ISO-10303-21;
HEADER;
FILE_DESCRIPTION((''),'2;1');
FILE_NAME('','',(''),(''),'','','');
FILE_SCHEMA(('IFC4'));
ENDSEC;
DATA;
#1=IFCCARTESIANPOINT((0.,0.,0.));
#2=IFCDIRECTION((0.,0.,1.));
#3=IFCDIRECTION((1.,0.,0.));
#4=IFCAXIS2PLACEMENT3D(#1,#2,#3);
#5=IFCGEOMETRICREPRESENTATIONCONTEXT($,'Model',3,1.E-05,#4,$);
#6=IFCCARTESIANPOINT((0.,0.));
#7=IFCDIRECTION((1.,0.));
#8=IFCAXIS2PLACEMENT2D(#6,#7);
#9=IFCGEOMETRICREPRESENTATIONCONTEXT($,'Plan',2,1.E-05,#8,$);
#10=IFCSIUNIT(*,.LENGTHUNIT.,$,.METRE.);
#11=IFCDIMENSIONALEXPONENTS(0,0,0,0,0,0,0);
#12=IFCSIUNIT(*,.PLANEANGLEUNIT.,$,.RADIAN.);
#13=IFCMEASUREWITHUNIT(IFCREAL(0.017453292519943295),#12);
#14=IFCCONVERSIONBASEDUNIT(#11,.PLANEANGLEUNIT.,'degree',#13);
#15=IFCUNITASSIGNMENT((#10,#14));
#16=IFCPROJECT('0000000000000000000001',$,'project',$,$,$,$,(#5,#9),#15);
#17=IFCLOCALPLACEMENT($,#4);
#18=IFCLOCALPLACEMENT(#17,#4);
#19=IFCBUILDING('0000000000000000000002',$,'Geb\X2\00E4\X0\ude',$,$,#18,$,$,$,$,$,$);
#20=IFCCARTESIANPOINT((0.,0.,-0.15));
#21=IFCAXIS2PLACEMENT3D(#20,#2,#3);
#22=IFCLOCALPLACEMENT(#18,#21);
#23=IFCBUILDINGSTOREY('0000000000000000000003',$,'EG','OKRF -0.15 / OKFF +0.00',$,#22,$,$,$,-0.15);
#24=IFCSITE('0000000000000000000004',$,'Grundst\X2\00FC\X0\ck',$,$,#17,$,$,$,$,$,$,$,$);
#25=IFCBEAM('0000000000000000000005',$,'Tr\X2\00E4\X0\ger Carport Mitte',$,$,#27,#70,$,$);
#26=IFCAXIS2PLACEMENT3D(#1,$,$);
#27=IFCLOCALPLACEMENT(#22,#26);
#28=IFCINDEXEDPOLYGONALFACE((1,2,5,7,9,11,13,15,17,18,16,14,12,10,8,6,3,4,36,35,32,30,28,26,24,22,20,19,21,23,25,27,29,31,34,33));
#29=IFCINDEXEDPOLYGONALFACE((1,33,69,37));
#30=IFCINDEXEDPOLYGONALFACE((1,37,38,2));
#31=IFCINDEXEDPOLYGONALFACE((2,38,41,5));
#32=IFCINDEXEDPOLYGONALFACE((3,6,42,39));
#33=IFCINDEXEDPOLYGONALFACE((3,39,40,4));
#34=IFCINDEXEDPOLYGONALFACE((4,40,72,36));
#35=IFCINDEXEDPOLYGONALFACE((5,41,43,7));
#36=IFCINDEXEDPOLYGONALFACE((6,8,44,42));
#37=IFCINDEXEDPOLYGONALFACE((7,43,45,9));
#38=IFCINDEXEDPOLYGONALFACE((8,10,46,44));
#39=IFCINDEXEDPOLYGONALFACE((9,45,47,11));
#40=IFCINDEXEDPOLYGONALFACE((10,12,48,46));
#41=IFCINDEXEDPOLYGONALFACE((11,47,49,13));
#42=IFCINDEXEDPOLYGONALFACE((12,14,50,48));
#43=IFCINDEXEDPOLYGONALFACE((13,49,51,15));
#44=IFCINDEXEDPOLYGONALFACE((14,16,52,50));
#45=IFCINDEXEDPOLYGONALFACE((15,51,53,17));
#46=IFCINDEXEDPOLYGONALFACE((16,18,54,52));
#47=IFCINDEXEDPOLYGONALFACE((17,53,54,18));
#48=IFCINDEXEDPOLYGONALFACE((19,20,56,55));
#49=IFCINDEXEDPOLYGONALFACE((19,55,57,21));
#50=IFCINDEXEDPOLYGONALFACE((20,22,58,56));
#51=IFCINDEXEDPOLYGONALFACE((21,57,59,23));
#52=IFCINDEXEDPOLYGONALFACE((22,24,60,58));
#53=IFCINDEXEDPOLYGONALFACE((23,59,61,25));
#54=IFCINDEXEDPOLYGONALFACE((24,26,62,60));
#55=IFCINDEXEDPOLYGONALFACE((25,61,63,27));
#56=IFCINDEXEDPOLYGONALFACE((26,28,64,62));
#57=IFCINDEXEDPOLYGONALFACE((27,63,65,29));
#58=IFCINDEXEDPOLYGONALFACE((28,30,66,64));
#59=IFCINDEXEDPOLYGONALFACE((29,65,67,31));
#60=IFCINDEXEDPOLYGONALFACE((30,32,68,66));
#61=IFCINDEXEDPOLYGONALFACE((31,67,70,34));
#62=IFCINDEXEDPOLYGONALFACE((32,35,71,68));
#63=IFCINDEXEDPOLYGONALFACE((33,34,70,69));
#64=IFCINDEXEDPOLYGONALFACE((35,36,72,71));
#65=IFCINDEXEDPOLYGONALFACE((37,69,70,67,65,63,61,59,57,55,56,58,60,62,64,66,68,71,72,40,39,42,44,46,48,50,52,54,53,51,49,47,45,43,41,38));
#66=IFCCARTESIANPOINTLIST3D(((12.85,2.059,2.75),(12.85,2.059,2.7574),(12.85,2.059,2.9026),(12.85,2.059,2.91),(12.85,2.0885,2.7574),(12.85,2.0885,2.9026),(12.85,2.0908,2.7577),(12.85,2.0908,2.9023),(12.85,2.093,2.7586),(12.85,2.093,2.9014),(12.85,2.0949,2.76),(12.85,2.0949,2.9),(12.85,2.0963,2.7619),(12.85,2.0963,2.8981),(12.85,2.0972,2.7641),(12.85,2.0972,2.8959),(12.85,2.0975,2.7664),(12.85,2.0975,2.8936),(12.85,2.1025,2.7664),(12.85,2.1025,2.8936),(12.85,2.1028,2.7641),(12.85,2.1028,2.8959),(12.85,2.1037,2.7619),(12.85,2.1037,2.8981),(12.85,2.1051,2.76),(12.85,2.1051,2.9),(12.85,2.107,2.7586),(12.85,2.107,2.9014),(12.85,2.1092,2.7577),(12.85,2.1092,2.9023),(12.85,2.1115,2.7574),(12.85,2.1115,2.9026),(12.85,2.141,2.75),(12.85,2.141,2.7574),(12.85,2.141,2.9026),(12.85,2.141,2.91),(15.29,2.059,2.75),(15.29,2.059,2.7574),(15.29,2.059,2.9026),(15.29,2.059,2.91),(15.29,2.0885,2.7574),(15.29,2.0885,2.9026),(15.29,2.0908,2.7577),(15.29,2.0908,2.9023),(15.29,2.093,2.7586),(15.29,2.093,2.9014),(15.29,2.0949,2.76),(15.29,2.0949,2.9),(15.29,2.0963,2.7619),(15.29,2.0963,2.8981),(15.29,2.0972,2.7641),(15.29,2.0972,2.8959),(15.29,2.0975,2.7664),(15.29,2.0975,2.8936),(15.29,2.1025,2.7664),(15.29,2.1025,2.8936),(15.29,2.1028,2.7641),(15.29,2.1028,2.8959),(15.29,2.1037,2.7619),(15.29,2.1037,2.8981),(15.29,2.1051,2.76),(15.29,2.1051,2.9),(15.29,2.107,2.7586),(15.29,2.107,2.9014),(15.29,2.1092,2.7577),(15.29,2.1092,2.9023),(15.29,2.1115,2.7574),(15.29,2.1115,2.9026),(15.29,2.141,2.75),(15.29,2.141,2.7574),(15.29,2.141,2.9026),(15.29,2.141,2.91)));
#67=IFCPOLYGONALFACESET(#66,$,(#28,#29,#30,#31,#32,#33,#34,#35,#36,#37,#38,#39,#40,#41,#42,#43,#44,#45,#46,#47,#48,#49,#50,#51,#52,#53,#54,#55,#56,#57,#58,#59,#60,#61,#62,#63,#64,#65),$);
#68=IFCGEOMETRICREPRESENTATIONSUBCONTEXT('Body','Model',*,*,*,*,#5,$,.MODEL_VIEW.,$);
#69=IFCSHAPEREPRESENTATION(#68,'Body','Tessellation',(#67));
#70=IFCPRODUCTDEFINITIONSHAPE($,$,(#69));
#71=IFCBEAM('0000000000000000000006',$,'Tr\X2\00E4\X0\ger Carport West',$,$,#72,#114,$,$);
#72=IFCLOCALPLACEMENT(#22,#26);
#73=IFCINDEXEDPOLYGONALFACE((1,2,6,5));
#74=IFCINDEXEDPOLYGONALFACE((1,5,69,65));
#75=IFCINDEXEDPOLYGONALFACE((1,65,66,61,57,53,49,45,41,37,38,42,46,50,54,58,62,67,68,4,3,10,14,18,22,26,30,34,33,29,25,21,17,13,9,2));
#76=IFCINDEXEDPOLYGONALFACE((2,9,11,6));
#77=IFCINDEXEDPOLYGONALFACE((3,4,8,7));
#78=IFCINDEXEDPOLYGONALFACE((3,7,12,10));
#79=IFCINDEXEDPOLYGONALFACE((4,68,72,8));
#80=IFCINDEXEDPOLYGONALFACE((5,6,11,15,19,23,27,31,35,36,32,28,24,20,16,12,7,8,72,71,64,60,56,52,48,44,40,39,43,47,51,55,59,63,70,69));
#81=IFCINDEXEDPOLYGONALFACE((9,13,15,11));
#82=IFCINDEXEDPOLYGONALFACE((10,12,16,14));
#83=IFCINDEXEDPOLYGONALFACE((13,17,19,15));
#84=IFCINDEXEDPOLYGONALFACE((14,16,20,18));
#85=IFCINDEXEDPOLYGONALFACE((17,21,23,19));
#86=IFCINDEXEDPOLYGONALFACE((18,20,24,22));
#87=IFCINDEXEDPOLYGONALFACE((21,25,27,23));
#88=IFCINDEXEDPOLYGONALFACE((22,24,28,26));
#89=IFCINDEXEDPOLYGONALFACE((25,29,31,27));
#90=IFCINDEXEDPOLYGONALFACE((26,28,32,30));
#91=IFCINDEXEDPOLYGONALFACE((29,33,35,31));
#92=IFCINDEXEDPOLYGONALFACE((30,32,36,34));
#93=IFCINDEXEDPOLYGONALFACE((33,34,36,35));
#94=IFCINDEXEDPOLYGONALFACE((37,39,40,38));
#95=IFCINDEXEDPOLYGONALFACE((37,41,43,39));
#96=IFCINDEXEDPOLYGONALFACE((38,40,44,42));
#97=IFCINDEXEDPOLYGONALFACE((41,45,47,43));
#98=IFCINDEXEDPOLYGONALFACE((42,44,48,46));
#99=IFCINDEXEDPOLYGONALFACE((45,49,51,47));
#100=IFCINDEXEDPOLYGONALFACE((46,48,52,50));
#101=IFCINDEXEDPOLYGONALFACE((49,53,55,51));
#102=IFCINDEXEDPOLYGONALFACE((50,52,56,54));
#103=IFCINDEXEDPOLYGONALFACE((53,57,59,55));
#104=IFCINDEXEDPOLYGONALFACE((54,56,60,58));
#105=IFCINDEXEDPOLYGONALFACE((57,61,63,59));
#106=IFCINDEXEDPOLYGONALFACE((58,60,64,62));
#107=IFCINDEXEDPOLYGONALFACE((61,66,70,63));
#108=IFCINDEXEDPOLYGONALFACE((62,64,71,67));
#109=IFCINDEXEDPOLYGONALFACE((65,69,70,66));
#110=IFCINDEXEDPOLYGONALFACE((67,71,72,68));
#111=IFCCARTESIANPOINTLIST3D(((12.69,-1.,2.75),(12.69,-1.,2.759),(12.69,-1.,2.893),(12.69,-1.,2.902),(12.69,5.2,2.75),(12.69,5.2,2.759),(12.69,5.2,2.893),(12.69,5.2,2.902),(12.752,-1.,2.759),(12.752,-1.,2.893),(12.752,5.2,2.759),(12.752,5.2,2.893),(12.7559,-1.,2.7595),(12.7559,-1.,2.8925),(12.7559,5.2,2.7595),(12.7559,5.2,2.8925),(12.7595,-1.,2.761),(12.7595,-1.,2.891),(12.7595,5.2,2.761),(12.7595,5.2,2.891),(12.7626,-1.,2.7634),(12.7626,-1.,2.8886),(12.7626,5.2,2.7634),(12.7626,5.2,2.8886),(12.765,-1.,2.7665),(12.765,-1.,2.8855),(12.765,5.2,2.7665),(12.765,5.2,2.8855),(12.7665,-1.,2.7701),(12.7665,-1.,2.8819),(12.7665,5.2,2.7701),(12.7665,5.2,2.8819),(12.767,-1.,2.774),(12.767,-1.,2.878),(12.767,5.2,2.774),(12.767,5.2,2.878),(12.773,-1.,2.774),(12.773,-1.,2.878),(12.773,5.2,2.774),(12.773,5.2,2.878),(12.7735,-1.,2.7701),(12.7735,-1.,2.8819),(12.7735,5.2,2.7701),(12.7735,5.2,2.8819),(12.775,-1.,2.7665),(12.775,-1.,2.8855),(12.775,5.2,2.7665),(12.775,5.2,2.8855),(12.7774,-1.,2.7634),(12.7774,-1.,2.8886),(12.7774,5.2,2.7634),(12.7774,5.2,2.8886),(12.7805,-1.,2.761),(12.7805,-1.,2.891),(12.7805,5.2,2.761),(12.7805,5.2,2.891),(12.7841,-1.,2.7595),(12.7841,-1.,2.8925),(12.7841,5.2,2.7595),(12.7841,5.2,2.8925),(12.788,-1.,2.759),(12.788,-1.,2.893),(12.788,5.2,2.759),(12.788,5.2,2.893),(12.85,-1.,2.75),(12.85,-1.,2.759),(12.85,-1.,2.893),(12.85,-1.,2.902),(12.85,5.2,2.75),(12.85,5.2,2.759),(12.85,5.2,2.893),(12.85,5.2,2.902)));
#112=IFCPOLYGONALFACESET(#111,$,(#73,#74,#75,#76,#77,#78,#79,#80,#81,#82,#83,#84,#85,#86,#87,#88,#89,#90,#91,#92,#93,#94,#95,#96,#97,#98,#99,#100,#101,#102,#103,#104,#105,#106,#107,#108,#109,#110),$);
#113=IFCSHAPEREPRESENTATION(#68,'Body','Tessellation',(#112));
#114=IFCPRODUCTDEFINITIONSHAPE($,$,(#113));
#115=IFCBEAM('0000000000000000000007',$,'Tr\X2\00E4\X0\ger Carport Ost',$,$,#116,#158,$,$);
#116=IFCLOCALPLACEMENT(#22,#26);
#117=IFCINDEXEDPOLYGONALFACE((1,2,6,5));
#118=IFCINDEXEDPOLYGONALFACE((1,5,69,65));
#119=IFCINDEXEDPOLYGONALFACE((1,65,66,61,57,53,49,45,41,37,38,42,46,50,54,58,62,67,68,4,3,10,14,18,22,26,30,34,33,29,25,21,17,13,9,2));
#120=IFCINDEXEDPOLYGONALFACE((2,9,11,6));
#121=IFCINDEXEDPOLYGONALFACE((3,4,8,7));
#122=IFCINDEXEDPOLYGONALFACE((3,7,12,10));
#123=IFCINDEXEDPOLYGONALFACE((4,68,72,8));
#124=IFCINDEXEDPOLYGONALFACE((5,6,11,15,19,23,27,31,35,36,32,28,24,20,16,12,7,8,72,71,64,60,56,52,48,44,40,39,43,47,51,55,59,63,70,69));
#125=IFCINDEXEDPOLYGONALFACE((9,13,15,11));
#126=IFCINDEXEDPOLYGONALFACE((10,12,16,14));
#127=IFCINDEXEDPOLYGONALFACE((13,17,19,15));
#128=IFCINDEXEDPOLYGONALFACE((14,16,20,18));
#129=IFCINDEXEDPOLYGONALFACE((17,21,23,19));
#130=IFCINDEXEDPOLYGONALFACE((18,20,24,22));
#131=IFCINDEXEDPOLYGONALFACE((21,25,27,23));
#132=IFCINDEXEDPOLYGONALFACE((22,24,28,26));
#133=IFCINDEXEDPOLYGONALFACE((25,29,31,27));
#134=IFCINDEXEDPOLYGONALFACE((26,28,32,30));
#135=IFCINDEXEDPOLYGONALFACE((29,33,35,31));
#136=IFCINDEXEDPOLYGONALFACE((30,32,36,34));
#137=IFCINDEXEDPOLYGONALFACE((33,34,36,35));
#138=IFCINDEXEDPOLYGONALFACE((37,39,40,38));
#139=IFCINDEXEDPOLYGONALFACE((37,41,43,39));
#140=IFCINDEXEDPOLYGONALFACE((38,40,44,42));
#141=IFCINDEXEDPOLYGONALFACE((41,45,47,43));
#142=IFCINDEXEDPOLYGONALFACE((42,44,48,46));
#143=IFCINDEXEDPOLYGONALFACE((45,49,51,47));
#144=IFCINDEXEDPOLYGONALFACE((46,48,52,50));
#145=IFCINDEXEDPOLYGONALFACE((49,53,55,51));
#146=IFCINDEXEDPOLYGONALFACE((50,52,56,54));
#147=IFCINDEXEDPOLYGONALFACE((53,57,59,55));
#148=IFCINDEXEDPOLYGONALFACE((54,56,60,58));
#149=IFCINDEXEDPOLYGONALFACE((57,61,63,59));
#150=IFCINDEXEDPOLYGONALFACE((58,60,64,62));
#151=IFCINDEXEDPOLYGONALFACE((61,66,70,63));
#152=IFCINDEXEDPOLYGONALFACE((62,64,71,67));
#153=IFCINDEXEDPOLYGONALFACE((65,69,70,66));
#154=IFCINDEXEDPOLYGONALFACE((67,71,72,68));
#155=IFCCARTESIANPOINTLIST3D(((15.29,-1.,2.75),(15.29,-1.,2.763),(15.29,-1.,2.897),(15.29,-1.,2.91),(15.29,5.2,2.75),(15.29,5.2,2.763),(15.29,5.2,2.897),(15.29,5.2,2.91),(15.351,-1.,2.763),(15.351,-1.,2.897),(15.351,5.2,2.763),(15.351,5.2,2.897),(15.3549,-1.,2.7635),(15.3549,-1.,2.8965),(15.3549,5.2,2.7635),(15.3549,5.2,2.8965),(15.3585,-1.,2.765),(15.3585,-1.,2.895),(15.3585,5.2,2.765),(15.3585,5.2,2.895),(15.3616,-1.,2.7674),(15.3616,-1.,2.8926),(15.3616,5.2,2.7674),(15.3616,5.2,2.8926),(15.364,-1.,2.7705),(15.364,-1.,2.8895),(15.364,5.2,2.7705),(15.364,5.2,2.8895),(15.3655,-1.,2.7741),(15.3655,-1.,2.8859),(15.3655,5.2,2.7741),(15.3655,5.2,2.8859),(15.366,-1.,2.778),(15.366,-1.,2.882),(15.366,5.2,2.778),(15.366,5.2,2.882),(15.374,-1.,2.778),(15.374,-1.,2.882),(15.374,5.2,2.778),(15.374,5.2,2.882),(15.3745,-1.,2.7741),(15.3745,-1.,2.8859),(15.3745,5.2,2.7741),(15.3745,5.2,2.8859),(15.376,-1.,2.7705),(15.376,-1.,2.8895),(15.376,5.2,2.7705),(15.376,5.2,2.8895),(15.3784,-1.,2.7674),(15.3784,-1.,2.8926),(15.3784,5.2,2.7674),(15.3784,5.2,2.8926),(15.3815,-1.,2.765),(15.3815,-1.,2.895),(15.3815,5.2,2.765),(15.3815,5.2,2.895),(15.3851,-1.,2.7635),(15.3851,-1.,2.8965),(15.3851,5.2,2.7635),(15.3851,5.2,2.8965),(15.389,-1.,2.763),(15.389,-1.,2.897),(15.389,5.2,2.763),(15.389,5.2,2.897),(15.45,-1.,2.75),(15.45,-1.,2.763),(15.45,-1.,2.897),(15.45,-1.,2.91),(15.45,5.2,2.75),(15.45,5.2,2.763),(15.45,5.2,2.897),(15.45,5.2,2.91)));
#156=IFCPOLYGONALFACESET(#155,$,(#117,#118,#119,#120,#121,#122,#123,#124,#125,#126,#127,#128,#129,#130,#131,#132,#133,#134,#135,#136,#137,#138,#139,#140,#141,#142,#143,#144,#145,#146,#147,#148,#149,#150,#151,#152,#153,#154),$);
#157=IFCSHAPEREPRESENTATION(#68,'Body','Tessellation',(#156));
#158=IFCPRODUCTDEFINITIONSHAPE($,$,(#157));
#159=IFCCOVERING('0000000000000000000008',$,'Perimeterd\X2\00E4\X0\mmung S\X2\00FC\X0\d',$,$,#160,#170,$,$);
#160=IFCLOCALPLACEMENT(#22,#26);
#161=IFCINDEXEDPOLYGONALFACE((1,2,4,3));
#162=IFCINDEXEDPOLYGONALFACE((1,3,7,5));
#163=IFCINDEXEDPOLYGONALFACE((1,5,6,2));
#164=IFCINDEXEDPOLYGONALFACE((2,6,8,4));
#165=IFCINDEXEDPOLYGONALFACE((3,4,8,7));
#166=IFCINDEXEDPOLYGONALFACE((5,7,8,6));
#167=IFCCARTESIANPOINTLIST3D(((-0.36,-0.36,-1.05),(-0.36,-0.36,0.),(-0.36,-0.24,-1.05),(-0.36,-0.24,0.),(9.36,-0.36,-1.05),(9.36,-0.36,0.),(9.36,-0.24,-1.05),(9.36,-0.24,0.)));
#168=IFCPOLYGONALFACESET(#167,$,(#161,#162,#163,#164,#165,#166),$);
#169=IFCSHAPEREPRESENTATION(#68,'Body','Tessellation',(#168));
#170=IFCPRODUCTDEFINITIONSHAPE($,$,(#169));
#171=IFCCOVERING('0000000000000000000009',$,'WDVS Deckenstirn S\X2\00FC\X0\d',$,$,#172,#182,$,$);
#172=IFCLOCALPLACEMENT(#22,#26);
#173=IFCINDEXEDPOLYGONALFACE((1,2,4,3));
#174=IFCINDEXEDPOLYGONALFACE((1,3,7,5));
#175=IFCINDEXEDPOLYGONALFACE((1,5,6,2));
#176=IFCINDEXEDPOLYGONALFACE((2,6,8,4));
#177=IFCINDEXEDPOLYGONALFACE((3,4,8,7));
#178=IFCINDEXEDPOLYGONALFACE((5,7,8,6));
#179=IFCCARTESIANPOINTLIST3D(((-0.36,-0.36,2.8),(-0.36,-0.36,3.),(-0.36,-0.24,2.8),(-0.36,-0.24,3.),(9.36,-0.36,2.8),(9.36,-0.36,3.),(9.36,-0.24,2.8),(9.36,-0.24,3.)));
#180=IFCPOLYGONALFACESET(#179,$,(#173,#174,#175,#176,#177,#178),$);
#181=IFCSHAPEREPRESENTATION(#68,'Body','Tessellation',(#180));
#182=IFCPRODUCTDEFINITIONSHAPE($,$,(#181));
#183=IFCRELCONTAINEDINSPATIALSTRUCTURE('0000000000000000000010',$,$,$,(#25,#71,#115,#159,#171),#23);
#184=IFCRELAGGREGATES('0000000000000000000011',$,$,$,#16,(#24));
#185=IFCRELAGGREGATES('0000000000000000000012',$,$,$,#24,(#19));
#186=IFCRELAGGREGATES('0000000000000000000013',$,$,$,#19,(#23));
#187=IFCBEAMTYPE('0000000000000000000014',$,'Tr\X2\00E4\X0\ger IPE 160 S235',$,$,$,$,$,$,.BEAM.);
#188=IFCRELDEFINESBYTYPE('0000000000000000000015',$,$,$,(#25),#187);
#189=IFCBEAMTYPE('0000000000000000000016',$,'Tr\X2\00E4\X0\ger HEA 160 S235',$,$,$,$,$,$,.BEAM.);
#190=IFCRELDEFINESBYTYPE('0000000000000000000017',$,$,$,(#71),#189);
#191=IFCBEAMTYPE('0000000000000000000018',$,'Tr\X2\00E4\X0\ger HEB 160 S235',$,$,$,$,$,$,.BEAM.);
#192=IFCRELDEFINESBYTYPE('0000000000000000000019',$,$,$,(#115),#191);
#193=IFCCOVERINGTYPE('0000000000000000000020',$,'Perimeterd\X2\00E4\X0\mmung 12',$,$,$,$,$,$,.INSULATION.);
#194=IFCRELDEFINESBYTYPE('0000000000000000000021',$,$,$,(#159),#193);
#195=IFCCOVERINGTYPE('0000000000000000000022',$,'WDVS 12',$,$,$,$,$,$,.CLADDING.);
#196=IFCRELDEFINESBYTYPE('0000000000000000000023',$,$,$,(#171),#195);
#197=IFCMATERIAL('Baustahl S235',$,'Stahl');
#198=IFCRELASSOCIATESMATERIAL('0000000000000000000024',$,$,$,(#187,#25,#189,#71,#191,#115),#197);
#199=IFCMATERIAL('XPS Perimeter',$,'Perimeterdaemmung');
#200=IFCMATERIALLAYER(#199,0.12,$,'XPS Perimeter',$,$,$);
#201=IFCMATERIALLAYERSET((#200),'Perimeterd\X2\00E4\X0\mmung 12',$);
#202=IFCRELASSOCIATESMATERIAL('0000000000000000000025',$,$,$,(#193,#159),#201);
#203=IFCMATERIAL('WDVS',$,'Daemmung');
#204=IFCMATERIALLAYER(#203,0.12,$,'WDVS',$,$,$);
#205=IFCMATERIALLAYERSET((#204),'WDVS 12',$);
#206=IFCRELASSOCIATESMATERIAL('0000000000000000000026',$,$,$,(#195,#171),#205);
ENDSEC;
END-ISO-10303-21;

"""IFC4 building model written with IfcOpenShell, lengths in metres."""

from ifc_helpers import new_model, entity, si_unit, converted_unit, frame, origin_with_axes, origin_2d_with_axis, place, context, subcontext, project, spatial, indexed_curve, i_section, outline, extrude, material, layer, layer_set, layer_usage, material_profile, profile_set, profile_usage, type_object, element, save


model = new_model("IFC4")

# Units and contexts
model_context = context("Model", 3, precision=1e-05, world=origin_with_axes())
plan_context = context("Plan", 2, precision=1e-05, world=origin_2d_with_axis())
body_context = subcontext(model_context, "Body", "Model", "MODEL_VIEW")
ifc_project = project(units=[si_unit("LENGTHUNIT", "METRE"), converted_unit("PLANEANGLEUNIT", "degree", entity("IfcReal", 0.017453292519943295), si_unit("PLANEANGLEUNIT", "RADIAN"), dimensions=[0, 0, 0, 0, 0, 0, 0])], contexts=[model_context, plan_context])

# Site, building, storey
site_placement = place(None, origin_with_axes())
site = spatial("IfcSite", under=ifc_project, at=site_placement, Name="Grundstück")
building_placement = place(site_placement, origin_with_axes())
building = spatial("IfcBuilding", under=site, at=building_placement, Name="Gebäude")
storey_placement = place(building_placement, frame((0.0, 0.0, -0.15), z_axis=(0.0, 0.0, 1.0), x_axis=(1.0, 0.0, 0.0)))
storey = spatial("IfcBuildingStorey", under=building, at=storey_placement, Name="EG", Description="OKRF -0.15 / OKFF +0.00", Elevation=-0.15)

# Shared definitions
ifc_material_1 = material(Name="Baustahl S235", Category="Stahl")

# Beams
ifc_material_profile_1 = material_profile(ifc_material_1, i_section(OverallWidth=0.082, OverallDepth=0.16, WebThickness=0.005, FlangeThickness=0.0074, FilletRadius=0.009))
ifc_profile_set_1 = profile_set([ifc_material_profile_1], Name="Träger IPE 160 S235")
ifc_profile_usage_1 = profile_usage(ifc_profile_set_1)
beam_type_1 = type_object("IfcBeamType", Name="Träger IPE 160 S235", PredefinedType="BEAM", material=ifc_profile_set_1)
beam_1_placement = place(storey_placement, frame((12.85, 2.1, 2.83), z_axis=(1.0, 0.0, 0.0), x_axis=(0.0, 1.0, 0.0)))
element("IfcBeam", 1, at=beam_1_placement, inside=storey, type_object=beam_type_1, material=ifc_profile_usage_1, Name="Träger Carport Mitte", context=body_context, shape_type="SweptSolid", body=[
    extrude(i_section(OverallWidth=0.082, OverallDepth=0.16, WebThickness=0.005, FlangeThickness=0.0074, FilletRadius=0.009), origin_with_axes(), (0.0, 0.0, 1.0), 2.44),
])
ifc_material_profile_2 = material_profile(ifc_material_1, i_section(OverallWidth=0.16, OverallDepth=0.152, WebThickness=0.006, FlangeThickness=0.009, FilletRadius=0.015))
ifc_profile_set_2 = profile_set([ifc_material_profile_2], Name="Träger HEA 160 S235")
ifc_profile_usage_2 = profile_usage(ifc_profile_set_2)
beam_type_2 = type_object("IfcBeamType", Name="Träger HEA 160 S235", PredefinedType="BEAM", material=ifc_profile_set_2)
beam_2_placement = place(storey_placement, frame((12.77, -1.0, 2.826), z_axis=(0.0, 1.0, 0.0), x_axis=(-1.0, 0.0, 0.0)))
element("IfcBeam", 2, at=beam_2_placement, inside=storey, type_object=beam_type_2, material=ifc_profile_usage_2, Name="Träger Carport West", context=body_context, shape_type="SweptSolid", body=[
    extrude(i_section(OverallWidth=0.16, OverallDepth=0.152, WebThickness=0.006, FlangeThickness=0.009, FilletRadius=0.015), origin_with_axes(), (0.0, 0.0, 1.0), 6.2),
])
ifc_material_profile_3 = material_profile(ifc_material_1, i_section(OverallWidth=0.16, OverallDepth=0.16, WebThickness=0.008, FlangeThickness=0.013, FilletRadius=0.015))
ifc_profile_set_3 = profile_set([ifc_material_profile_3], Name="Träger HEB 160 S235")
ifc_profile_usage_3 = profile_usage(ifc_profile_set_3)
beam_type_3 = type_object("IfcBeamType", Name="Träger HEB 160 S235", PredefinedType="BEAM", material=ifc_profile_set_3)
beam_3_placement = place(storey_placement, frame((15.37, -1.0, 2.83), z_axis=(0.0, 1.0, 0.0), x_axis=(-1.0, 0.0, 0.0)))
element("IfcBeam", 3, at=beam_3_placement, inside=storey, type_object=beam_type_3, material=ifc_profile_usage_3, Name="Träger Carport Ost", context=body_context, shape_type="SweptSolid", body=[
    extrude(i_section(OverallWidth=0.16, OverallDepth=0.16, WebThickness=0.008, FlangeThickness=0.013, FilletRadius=0.015), origin_with_axes(), (0.0, 0.0, 1.0), 6.2),
])

# Coverings
ifc_material_2 = material(Name="XPS Perimeter", Category="Perimeterdaemmung")
ifc_layer_1 = layer(ifc_material_2, 0.12, Name="XPS Perimeter")
ifc_layer_set_1 = layer_set([ifc_layer_1], Name="Perimeterdämmung 12")
ifc_layer_usage_1 = layer_usage(ifc_layer_set_1, "AXIS2", "POSITIVE", 0.0)
covering_type_1 = type_object("IfcCoveringType", Name="Perimeterdämmung 12", PredefinedType="INSULATION", material=ifc_layer_set_1)
covering_1_placement = place(storey_placement, frame((9.36, -0.24, -1.05), z_axis=(0.0, 0.0, 1.0), x_axis=(-1.0, 0.0, 0.0)))
element("IfcCovering", 4, at=covering_1_placement, inside=storey, type_object=covering_type_1, material=ifc_layer_usage_1, Name="Perimeterdämmung Süd", context=body_context, shape_type="SweptSolid", body=[
    extrude(outline(indexed_curve([(0.0, 0.0), (0.0, 0.12), (9.72, 0.12), (9.72, 0.0), (0.0, 0.0)], self_intersect=False)), origin_with_axes(), (0.0, 0.0, 1.0), 1.05),
])
ifc_material_3 = material(Name="WDVS", Category="Daemmung")
ifc_layer_2 = layer(ifc_material_3, 0.12, Name="WDVS")
ifc_layer_set_2 = layer_set([ifc_layer_2], Name="WDVS 12")
ifc_layer_usage_2 = layer_usage(ifc_layer_set_2, "AXIS2", "POSITIVE", 0.0)
covering_type_2 = type_object("IfcCoveringType", Name="WDVS 12", PredefinedType="CLADDING", material=ifc_layer_set_2)
covering_2_placement = place(storey_placement, frame((9.36, -0.24, 2.8), z_axis=(0.0, 0.0, 1.0), x_axis=(-1.0, 0.0, 0.0)))
element("IfcCovering", 5, at=covering_2_placement, inside=storey, type_object=covering_type_2, material=ifc_layer_usage_2, Name="WDVS Deckenstirn Süd", context=body_context, shape_type="SweptSolid", body=[
    extrude(outline(indexed_curve([(0.0, 0.0), (0.0, 0.12), (9.72, 0.12), (9.72, 0.0), (0.0, 0.0)], self_intersect=False)), origin_with_axes(), (0.0, 0.0, 1.0), 0.2),
])

save(model, "model.ifc")
